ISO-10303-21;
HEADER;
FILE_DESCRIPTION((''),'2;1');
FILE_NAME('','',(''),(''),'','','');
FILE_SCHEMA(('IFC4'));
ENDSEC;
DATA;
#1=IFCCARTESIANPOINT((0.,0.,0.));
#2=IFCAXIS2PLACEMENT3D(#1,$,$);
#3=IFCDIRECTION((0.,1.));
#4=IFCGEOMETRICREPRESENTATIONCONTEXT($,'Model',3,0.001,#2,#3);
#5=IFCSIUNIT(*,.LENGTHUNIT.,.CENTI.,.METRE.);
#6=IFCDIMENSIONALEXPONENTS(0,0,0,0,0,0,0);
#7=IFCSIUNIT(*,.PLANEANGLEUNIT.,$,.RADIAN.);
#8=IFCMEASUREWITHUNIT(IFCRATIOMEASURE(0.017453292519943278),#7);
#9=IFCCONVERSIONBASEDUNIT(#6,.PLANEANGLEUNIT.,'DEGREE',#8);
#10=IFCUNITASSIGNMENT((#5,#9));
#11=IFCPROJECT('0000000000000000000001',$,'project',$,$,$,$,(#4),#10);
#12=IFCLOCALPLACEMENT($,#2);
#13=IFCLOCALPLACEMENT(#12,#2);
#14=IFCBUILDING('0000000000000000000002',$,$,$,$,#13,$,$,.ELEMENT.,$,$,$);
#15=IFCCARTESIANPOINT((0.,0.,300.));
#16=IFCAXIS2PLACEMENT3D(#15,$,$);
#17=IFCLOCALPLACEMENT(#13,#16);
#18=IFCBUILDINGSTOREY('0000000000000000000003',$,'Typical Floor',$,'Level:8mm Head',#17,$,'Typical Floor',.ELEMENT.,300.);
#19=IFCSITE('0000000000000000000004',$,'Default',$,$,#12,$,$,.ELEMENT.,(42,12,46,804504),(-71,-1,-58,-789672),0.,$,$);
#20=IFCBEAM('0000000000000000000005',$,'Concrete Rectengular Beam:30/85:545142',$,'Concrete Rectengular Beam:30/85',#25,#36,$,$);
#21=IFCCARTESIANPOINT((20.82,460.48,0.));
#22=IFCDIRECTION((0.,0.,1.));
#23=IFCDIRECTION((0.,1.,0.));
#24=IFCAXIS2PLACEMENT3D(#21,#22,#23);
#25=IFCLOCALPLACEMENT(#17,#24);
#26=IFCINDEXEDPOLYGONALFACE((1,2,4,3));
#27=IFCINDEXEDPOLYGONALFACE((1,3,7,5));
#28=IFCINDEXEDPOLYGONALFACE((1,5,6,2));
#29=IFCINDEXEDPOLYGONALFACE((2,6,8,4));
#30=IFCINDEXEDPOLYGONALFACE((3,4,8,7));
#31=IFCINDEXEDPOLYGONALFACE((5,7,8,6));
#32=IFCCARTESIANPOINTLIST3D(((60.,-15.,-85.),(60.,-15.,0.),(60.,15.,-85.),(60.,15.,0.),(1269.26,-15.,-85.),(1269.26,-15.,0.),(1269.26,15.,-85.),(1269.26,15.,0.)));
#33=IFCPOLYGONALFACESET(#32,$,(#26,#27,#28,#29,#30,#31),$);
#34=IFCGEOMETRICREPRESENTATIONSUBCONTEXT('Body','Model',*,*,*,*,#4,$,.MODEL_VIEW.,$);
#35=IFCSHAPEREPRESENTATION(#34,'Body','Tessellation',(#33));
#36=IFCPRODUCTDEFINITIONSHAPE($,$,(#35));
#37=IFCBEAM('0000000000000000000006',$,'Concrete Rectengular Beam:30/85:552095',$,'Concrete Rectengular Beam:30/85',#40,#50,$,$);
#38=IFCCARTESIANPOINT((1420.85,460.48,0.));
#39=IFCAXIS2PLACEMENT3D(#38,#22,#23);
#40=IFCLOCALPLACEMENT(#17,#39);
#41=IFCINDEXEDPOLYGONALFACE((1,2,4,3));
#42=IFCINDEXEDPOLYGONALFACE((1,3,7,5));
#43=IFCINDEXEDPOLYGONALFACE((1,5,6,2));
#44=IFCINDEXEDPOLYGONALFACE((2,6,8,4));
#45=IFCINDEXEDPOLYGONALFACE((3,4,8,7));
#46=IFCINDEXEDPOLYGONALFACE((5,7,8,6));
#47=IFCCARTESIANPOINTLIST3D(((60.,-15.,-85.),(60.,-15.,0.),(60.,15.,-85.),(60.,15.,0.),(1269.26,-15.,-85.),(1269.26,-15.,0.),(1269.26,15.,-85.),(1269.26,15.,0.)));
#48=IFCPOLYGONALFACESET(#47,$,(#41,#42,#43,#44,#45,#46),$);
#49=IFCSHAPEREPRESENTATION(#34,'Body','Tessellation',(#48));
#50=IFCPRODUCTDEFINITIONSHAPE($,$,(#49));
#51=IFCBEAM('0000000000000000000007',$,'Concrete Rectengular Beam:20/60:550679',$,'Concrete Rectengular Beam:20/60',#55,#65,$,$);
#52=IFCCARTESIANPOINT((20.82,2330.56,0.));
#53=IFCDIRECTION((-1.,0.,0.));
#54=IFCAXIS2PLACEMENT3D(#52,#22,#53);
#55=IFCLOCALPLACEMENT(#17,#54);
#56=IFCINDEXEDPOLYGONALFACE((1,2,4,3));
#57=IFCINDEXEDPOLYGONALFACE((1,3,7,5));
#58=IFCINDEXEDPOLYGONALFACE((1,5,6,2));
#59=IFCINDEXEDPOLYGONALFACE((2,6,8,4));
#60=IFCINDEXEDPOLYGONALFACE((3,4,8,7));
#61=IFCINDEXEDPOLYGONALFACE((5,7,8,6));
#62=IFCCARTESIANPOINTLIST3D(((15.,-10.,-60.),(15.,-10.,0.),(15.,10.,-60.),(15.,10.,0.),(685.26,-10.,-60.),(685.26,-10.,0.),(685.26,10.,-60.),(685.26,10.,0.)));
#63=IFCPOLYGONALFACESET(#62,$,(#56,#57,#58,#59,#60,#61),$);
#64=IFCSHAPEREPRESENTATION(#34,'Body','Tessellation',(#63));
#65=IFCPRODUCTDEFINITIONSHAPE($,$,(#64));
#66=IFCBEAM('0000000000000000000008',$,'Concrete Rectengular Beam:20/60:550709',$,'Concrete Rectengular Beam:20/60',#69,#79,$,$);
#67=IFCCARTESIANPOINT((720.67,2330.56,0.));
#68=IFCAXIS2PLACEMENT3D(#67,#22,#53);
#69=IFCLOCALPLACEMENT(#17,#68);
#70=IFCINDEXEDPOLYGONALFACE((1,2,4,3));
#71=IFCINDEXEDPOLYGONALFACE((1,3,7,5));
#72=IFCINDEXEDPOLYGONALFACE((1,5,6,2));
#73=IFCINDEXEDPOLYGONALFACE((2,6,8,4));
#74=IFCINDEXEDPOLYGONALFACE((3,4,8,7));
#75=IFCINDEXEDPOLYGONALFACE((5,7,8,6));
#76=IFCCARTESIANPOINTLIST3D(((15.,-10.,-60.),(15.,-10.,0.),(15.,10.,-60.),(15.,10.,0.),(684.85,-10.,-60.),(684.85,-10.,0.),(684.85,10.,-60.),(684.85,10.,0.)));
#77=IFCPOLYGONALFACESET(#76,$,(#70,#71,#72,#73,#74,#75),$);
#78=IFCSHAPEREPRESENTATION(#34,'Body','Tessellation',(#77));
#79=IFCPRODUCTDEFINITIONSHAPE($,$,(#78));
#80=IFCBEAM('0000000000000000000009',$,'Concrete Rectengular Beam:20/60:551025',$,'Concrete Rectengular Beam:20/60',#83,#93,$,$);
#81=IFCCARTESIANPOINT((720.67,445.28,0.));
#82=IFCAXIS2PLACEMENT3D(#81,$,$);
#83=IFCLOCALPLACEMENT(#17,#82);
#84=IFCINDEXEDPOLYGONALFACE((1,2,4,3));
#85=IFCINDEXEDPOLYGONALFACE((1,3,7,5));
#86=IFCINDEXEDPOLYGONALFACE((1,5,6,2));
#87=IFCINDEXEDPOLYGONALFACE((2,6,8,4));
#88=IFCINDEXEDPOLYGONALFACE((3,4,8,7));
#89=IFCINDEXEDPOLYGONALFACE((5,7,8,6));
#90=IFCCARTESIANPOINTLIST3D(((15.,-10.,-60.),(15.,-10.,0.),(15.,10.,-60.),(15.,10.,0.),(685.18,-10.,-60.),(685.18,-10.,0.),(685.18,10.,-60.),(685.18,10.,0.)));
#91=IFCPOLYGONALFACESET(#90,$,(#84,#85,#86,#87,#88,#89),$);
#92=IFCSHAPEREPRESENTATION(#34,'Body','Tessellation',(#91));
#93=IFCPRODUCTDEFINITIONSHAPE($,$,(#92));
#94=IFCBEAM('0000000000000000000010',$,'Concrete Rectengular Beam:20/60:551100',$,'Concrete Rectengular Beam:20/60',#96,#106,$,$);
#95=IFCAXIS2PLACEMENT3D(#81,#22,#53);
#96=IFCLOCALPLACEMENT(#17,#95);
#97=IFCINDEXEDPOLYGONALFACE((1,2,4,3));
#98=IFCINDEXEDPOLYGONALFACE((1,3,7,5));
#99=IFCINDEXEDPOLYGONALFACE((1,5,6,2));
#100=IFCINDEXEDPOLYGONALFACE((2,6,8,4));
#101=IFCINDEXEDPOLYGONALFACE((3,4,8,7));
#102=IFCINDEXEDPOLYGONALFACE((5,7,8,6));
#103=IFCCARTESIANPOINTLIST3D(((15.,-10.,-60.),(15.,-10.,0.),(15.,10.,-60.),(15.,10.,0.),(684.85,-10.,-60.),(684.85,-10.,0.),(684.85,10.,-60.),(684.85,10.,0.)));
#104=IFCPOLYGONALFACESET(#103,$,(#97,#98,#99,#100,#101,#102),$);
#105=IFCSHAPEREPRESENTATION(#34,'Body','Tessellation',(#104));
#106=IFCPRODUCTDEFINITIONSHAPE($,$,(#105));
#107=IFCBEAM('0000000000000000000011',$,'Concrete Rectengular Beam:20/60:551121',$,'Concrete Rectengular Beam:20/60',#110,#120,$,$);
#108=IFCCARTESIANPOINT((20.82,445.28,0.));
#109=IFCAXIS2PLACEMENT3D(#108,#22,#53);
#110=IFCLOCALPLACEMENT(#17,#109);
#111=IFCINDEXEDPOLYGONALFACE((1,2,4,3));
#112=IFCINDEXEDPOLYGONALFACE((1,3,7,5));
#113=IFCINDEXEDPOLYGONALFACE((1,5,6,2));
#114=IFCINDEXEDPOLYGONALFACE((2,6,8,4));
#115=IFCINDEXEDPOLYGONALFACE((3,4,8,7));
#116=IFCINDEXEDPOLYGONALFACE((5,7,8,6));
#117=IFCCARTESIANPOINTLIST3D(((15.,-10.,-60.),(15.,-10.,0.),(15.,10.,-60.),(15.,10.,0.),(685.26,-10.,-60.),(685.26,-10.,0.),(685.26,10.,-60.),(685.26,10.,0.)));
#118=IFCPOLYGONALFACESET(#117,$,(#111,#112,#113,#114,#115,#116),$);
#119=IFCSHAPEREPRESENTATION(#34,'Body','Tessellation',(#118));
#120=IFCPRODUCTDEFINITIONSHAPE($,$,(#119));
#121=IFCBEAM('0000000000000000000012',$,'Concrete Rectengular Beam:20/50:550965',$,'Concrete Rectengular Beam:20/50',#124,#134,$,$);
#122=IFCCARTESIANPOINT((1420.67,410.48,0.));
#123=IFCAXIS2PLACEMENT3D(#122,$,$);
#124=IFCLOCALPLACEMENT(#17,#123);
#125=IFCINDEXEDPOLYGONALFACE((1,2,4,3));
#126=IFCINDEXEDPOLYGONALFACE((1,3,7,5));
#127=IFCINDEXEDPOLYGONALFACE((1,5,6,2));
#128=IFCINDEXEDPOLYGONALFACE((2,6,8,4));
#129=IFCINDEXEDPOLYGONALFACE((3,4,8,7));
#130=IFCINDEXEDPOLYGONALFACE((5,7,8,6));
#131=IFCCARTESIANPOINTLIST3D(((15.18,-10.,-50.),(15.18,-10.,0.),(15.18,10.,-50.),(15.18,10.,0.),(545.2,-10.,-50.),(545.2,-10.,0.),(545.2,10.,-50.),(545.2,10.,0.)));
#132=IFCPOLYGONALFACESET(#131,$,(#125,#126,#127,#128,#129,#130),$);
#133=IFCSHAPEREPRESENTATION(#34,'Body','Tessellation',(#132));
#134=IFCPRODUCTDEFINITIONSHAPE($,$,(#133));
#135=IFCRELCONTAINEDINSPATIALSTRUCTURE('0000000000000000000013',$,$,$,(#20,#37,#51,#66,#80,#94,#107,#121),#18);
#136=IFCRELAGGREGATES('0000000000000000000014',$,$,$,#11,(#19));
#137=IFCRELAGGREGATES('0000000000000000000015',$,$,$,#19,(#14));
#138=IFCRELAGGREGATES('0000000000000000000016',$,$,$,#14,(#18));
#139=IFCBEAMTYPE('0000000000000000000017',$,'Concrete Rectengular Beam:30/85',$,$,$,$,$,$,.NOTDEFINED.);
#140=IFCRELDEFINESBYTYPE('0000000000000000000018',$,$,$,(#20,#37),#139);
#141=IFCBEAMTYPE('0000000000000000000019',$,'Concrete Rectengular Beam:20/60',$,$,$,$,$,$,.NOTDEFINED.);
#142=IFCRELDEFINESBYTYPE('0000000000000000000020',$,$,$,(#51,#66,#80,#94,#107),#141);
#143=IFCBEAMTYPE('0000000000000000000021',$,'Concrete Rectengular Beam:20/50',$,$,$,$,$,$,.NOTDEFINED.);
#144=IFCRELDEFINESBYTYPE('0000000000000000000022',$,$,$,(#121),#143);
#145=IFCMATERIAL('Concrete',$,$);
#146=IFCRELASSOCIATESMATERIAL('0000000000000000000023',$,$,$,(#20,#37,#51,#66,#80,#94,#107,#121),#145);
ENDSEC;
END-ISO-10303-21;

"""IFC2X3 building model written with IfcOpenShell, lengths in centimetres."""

from ifc_helpers import new_model, entity, si_unit, converted_unit, direction, frame, frame_2d, origin, place, context, subcontext, project, spatial, rectangle, extrude, material, type_object, element, save


model = new_model("IFC2X3")

# Units and contexts
model_context = context("Model", 3, precision=0.001, world=origin(), true_north=direction((0.0, 1.0)))
body_context = subcontext(model_context, "Body", "Model", "MODEL_VIEW")
ifc_project = project(units=[si_unit("LENGTHUNIT", "METRE", prefix="CENTI"), converted_unit("PLANEANGLEUNIT", "DEGREE", entity("IfcRatioMeasure", 0.017453292519943278), si_unit("PLANEANGLEUNIT", "RADIAN"), dimensions=[0, 0, 0, 0, 0, 0, 0])], contexts=[model_context])

# Site, building, storey
site_placement = place(None, origin())
site = spatial("IfcSite", under=ifc_project, at=site_placement, Name="Default", CompositionType="ELEMENT", RefLatitude=(42, 12, 46, 804504), RefLongitude=(-71, -1, -58, -789672), RefElevation=0.0)
building_placement = place(site_placement, origin())
building = spatial("IfcBuilding", under=site, at=building_placement, CompositionType="ELEMENT")
storey_placement = place(building_placement, frame((0.0, 0.0, 300.0)))
storey = spatial("IfcBuildingStorey", under=building, at=storey_placement, Name="Typical Floor", ObjectType="Level:8mm Head", LongName="Typical Floor", CompositionType="ELEMENT", Elevation=300.0)

# Beams
ifc_material = material(Name="Concrete")
beam_type_1 = type_object("IfcBeamType", Name="Concrete Rectengular Beam:30/85", PredefinedType="NOTDEFINED")
beam_1_placement = place(storey_placement, frame((20.82, 460.48, 0.0), z_axis=(0.0, 0.0, 1.0), x_axis=(0.0, 1.0, 0.0)))
element("IfcBeam", 1, at=beam_1_placement, inside=storey, type_object=beam_type_1, material=ifc_material, Name="Concrete Rectengular Beam:30/85:545142", ObjectType="Concrete Rectengular Beam:30/85", context=body_context, shape_type="SweptSolid", body=[
    extrude(rectangle(XDim=85.0, YDim=30.0, at=frame_2d((0.0, 0.0), x_axis=(1.0, 0.0))), frame((60.0, 0.0, -42.5), z_axis=(1.0, 0.0, 0.0), x_axis=(0.0, 0.0, -1.0)), (0.0, 0.0, 1.0), 1209.26),
])
beam_2_placement = place(storey_placement, frame((1420.85, 460.48, 0.0), z_axis=(0.0, 0.0, 1.0), x_axis=(0.0, 1.0, 0.0)))
element("IfcBeam", 2, at=beam_2_placement, inside=storey, type_object=beam_type_1, material=ifc_material, Name="Concrete Rectengular Beam:30/85:552095", ObjectType="Concrete Rectengular Beam:30/85", context=body_context, shape_type="SweptSolid", body=[
    extrude(rectangle(XDim=85.0, YDim=30.0, at=frame_2d((0.0, 0.0), x_axis=(1.0, 0.0))), frame((60.0, 0.0, -42.5), z_axis=(1.0, 0.0, 0.0), x_axis=(0.0, 0.0, -1.0)), (0.0, 0.0, 1.0), 1209.26),
])
beam_type_2 = type_object("IfcBeamType", Name="Concrete Rectengular Beam:20/60", PredefinedType="NOTDEFINED")
beam_3_placement = place(storey_placement, frame((20.82, 2330.56, 0.0), z_axis=(0.0, 0.0, 1.0), x_axis=(-1.0, 0.0, 0.0)))
element("IfcBeam", 3, at=beam_3_placement, inside=storey, type_object=beam_type_2, material=ifc_material, Name="Concrete Rectengular Beam:20/60:550679", ObjectType="Concrete Rectengular Beam:20/60", context=body_context, shape_type="SweptSolid", body=[
    extrude(rectangle(XDim=60.0, YDim=20.0, at=frame_2d((0.0, 0.0), x_axis=(1.0, 0.0))), frame((15.0, 0.0, -30.0), z_axis=(1.0, 0.0, 0.0), x_axis=(0.0, 0.0, -1.0)), (0.0, 0.0, 1.0), 670.26),
])
beam_4_placement = place(storey_placement, frame((720.67, 2330.56, 0.0), z_axis=(0.0, 0.0, 1.0), x_axis=(-1.0, 0.0, 0.0)))
element("IfcBeam", 4, at=beam_4_placement, inside=storey, type_object=beam_type_2, material=ifc_material, Name="Concrete Rectengular Beam:20/60:550709", ObjectType="Concrete Rectengular Beam:20/60", context=body_context, shape_type="SweptSolid", body=[
    extrude(rectangle(XDim=60.0, YDim=20.0, at=frame_2d((0.0, 0.0), x_axis=(1.0, 0.0))), frame((15.0, 0.0, -30.0), z_axis=(1.0, 0.0, 0.0), x_axis=(0.0, 0.0, -1.0)), (0.0, 0.0, 1.0), 669.85),
])
beam_5_placement = place(storey_placement, frame((720.67, 445.28, 0.0)))
element("IfcBeam", 5, at=beam_5_placement, inside=storey, type_object=beam_type_2, material=ifc_material, Name="Concrete Rectengular Beam:20/60:551025", ObjectType="Concrete Rectengular Beam:20/60", context=body_context, shape_type="SweptSolid", body=[
    extrude(rectangle(XDim=60.0, YDim=20.0, at=frame_2d((0.0, 0.0), x_axis=(1.0, 0.0))), frame((15.0, 0.0, -30.0), z_axis=(1.0, 0.0, 0.0), x_axis=(0.0, 0.0, -1.0)), (0.0, 0.0, 1.0), 670.18),
])
beam_6_placement = place(storey_placement, frame((720.67, 445.28, 0.0), z_axis=(0.0, 0.0, 1.0), x_axis=(-1.0, 0.0, 0.0)))
element("IfcBeam", 6, at=beam_6_placement, inside=storey, type_object=beam_type_2, material=ifc_material, Name="Concrete Rectengular Beam:20/60:551100", ObjectType="Concrete Rectengular Beam:20/60", context=body_context, shape_type="SweptSolid", body=[
    extrude(rectangle(XDim=60.0, YDim=20.0, at=frame_2d((0.0, 0.0), x_axis=(1.0, 0.0))), frame((15.0, 0.0, -30.0), z_axis=(1.0, 0.0, 0.0), x_axis=(0.0, 0.0, -1.0)), (0.0, 0.0, 1.0), 669.85),
])
beam_7_placement = place(storey_placement, frame((20.82, 445.28, 0.0), z_axis=(0.0, 0.0, 1.0), x_axis=(-1.0, 0.0, 0.0)))
element("IfcBeam", 7, at=beam_7_placement, inside=storey, type_object=beam_type_2, material=ifc_material, Name="Concrete Rectengular Beam:20/60:551121", ObjectType="Concrete Rectengular Beam:20/60", context=body_context, shape_type="SweptSolid", body=[
    extrude(rectangle(XDim=60.0, YDim=20.0, at=frame_2d((0.0, 0.0), x_axis=(1.0, 0.0))), frame((15.0, 0.0, -30.0), z_axis=(1.0, 0.0, 0.0), x_axis=(0.0, 0.0, -1.0)), (0.0, 0.0, 1.0), 670.26),
])
beam_type_3 = type_object("IfcBeamType", Name="Concrete Rectengular Beam:20/50", PredefinedType="NOTDEFINED")
beam_8_placement = place(storey_placement, frame((1420.67, 410.48, 0.0)))
element("IfcBeam", 8, at=beam_8_placement, inside=storey, type_object=beam_type_3, material=ifc_material, Name="Concrete Rectengular Beam:20/50:550965", ObjectType="Concrete Rectengular Beam:20/50", context=body_context, shape_type="SweptSolid", body=[
    extrude(rectangle(XDim=50.0, YDim=20.0, at=frame_2d((0.0, 0.0), x_axis=(1.0, 0.0))), frame((15.18, 0.0, -25.0), z_axis=(1.0, 0.0, 0.0), x_axis=(0.0, 0.0, -1.0)), (0.0, 0.0, 1.0), 530.02),
])

save(model, "model.ifc")
